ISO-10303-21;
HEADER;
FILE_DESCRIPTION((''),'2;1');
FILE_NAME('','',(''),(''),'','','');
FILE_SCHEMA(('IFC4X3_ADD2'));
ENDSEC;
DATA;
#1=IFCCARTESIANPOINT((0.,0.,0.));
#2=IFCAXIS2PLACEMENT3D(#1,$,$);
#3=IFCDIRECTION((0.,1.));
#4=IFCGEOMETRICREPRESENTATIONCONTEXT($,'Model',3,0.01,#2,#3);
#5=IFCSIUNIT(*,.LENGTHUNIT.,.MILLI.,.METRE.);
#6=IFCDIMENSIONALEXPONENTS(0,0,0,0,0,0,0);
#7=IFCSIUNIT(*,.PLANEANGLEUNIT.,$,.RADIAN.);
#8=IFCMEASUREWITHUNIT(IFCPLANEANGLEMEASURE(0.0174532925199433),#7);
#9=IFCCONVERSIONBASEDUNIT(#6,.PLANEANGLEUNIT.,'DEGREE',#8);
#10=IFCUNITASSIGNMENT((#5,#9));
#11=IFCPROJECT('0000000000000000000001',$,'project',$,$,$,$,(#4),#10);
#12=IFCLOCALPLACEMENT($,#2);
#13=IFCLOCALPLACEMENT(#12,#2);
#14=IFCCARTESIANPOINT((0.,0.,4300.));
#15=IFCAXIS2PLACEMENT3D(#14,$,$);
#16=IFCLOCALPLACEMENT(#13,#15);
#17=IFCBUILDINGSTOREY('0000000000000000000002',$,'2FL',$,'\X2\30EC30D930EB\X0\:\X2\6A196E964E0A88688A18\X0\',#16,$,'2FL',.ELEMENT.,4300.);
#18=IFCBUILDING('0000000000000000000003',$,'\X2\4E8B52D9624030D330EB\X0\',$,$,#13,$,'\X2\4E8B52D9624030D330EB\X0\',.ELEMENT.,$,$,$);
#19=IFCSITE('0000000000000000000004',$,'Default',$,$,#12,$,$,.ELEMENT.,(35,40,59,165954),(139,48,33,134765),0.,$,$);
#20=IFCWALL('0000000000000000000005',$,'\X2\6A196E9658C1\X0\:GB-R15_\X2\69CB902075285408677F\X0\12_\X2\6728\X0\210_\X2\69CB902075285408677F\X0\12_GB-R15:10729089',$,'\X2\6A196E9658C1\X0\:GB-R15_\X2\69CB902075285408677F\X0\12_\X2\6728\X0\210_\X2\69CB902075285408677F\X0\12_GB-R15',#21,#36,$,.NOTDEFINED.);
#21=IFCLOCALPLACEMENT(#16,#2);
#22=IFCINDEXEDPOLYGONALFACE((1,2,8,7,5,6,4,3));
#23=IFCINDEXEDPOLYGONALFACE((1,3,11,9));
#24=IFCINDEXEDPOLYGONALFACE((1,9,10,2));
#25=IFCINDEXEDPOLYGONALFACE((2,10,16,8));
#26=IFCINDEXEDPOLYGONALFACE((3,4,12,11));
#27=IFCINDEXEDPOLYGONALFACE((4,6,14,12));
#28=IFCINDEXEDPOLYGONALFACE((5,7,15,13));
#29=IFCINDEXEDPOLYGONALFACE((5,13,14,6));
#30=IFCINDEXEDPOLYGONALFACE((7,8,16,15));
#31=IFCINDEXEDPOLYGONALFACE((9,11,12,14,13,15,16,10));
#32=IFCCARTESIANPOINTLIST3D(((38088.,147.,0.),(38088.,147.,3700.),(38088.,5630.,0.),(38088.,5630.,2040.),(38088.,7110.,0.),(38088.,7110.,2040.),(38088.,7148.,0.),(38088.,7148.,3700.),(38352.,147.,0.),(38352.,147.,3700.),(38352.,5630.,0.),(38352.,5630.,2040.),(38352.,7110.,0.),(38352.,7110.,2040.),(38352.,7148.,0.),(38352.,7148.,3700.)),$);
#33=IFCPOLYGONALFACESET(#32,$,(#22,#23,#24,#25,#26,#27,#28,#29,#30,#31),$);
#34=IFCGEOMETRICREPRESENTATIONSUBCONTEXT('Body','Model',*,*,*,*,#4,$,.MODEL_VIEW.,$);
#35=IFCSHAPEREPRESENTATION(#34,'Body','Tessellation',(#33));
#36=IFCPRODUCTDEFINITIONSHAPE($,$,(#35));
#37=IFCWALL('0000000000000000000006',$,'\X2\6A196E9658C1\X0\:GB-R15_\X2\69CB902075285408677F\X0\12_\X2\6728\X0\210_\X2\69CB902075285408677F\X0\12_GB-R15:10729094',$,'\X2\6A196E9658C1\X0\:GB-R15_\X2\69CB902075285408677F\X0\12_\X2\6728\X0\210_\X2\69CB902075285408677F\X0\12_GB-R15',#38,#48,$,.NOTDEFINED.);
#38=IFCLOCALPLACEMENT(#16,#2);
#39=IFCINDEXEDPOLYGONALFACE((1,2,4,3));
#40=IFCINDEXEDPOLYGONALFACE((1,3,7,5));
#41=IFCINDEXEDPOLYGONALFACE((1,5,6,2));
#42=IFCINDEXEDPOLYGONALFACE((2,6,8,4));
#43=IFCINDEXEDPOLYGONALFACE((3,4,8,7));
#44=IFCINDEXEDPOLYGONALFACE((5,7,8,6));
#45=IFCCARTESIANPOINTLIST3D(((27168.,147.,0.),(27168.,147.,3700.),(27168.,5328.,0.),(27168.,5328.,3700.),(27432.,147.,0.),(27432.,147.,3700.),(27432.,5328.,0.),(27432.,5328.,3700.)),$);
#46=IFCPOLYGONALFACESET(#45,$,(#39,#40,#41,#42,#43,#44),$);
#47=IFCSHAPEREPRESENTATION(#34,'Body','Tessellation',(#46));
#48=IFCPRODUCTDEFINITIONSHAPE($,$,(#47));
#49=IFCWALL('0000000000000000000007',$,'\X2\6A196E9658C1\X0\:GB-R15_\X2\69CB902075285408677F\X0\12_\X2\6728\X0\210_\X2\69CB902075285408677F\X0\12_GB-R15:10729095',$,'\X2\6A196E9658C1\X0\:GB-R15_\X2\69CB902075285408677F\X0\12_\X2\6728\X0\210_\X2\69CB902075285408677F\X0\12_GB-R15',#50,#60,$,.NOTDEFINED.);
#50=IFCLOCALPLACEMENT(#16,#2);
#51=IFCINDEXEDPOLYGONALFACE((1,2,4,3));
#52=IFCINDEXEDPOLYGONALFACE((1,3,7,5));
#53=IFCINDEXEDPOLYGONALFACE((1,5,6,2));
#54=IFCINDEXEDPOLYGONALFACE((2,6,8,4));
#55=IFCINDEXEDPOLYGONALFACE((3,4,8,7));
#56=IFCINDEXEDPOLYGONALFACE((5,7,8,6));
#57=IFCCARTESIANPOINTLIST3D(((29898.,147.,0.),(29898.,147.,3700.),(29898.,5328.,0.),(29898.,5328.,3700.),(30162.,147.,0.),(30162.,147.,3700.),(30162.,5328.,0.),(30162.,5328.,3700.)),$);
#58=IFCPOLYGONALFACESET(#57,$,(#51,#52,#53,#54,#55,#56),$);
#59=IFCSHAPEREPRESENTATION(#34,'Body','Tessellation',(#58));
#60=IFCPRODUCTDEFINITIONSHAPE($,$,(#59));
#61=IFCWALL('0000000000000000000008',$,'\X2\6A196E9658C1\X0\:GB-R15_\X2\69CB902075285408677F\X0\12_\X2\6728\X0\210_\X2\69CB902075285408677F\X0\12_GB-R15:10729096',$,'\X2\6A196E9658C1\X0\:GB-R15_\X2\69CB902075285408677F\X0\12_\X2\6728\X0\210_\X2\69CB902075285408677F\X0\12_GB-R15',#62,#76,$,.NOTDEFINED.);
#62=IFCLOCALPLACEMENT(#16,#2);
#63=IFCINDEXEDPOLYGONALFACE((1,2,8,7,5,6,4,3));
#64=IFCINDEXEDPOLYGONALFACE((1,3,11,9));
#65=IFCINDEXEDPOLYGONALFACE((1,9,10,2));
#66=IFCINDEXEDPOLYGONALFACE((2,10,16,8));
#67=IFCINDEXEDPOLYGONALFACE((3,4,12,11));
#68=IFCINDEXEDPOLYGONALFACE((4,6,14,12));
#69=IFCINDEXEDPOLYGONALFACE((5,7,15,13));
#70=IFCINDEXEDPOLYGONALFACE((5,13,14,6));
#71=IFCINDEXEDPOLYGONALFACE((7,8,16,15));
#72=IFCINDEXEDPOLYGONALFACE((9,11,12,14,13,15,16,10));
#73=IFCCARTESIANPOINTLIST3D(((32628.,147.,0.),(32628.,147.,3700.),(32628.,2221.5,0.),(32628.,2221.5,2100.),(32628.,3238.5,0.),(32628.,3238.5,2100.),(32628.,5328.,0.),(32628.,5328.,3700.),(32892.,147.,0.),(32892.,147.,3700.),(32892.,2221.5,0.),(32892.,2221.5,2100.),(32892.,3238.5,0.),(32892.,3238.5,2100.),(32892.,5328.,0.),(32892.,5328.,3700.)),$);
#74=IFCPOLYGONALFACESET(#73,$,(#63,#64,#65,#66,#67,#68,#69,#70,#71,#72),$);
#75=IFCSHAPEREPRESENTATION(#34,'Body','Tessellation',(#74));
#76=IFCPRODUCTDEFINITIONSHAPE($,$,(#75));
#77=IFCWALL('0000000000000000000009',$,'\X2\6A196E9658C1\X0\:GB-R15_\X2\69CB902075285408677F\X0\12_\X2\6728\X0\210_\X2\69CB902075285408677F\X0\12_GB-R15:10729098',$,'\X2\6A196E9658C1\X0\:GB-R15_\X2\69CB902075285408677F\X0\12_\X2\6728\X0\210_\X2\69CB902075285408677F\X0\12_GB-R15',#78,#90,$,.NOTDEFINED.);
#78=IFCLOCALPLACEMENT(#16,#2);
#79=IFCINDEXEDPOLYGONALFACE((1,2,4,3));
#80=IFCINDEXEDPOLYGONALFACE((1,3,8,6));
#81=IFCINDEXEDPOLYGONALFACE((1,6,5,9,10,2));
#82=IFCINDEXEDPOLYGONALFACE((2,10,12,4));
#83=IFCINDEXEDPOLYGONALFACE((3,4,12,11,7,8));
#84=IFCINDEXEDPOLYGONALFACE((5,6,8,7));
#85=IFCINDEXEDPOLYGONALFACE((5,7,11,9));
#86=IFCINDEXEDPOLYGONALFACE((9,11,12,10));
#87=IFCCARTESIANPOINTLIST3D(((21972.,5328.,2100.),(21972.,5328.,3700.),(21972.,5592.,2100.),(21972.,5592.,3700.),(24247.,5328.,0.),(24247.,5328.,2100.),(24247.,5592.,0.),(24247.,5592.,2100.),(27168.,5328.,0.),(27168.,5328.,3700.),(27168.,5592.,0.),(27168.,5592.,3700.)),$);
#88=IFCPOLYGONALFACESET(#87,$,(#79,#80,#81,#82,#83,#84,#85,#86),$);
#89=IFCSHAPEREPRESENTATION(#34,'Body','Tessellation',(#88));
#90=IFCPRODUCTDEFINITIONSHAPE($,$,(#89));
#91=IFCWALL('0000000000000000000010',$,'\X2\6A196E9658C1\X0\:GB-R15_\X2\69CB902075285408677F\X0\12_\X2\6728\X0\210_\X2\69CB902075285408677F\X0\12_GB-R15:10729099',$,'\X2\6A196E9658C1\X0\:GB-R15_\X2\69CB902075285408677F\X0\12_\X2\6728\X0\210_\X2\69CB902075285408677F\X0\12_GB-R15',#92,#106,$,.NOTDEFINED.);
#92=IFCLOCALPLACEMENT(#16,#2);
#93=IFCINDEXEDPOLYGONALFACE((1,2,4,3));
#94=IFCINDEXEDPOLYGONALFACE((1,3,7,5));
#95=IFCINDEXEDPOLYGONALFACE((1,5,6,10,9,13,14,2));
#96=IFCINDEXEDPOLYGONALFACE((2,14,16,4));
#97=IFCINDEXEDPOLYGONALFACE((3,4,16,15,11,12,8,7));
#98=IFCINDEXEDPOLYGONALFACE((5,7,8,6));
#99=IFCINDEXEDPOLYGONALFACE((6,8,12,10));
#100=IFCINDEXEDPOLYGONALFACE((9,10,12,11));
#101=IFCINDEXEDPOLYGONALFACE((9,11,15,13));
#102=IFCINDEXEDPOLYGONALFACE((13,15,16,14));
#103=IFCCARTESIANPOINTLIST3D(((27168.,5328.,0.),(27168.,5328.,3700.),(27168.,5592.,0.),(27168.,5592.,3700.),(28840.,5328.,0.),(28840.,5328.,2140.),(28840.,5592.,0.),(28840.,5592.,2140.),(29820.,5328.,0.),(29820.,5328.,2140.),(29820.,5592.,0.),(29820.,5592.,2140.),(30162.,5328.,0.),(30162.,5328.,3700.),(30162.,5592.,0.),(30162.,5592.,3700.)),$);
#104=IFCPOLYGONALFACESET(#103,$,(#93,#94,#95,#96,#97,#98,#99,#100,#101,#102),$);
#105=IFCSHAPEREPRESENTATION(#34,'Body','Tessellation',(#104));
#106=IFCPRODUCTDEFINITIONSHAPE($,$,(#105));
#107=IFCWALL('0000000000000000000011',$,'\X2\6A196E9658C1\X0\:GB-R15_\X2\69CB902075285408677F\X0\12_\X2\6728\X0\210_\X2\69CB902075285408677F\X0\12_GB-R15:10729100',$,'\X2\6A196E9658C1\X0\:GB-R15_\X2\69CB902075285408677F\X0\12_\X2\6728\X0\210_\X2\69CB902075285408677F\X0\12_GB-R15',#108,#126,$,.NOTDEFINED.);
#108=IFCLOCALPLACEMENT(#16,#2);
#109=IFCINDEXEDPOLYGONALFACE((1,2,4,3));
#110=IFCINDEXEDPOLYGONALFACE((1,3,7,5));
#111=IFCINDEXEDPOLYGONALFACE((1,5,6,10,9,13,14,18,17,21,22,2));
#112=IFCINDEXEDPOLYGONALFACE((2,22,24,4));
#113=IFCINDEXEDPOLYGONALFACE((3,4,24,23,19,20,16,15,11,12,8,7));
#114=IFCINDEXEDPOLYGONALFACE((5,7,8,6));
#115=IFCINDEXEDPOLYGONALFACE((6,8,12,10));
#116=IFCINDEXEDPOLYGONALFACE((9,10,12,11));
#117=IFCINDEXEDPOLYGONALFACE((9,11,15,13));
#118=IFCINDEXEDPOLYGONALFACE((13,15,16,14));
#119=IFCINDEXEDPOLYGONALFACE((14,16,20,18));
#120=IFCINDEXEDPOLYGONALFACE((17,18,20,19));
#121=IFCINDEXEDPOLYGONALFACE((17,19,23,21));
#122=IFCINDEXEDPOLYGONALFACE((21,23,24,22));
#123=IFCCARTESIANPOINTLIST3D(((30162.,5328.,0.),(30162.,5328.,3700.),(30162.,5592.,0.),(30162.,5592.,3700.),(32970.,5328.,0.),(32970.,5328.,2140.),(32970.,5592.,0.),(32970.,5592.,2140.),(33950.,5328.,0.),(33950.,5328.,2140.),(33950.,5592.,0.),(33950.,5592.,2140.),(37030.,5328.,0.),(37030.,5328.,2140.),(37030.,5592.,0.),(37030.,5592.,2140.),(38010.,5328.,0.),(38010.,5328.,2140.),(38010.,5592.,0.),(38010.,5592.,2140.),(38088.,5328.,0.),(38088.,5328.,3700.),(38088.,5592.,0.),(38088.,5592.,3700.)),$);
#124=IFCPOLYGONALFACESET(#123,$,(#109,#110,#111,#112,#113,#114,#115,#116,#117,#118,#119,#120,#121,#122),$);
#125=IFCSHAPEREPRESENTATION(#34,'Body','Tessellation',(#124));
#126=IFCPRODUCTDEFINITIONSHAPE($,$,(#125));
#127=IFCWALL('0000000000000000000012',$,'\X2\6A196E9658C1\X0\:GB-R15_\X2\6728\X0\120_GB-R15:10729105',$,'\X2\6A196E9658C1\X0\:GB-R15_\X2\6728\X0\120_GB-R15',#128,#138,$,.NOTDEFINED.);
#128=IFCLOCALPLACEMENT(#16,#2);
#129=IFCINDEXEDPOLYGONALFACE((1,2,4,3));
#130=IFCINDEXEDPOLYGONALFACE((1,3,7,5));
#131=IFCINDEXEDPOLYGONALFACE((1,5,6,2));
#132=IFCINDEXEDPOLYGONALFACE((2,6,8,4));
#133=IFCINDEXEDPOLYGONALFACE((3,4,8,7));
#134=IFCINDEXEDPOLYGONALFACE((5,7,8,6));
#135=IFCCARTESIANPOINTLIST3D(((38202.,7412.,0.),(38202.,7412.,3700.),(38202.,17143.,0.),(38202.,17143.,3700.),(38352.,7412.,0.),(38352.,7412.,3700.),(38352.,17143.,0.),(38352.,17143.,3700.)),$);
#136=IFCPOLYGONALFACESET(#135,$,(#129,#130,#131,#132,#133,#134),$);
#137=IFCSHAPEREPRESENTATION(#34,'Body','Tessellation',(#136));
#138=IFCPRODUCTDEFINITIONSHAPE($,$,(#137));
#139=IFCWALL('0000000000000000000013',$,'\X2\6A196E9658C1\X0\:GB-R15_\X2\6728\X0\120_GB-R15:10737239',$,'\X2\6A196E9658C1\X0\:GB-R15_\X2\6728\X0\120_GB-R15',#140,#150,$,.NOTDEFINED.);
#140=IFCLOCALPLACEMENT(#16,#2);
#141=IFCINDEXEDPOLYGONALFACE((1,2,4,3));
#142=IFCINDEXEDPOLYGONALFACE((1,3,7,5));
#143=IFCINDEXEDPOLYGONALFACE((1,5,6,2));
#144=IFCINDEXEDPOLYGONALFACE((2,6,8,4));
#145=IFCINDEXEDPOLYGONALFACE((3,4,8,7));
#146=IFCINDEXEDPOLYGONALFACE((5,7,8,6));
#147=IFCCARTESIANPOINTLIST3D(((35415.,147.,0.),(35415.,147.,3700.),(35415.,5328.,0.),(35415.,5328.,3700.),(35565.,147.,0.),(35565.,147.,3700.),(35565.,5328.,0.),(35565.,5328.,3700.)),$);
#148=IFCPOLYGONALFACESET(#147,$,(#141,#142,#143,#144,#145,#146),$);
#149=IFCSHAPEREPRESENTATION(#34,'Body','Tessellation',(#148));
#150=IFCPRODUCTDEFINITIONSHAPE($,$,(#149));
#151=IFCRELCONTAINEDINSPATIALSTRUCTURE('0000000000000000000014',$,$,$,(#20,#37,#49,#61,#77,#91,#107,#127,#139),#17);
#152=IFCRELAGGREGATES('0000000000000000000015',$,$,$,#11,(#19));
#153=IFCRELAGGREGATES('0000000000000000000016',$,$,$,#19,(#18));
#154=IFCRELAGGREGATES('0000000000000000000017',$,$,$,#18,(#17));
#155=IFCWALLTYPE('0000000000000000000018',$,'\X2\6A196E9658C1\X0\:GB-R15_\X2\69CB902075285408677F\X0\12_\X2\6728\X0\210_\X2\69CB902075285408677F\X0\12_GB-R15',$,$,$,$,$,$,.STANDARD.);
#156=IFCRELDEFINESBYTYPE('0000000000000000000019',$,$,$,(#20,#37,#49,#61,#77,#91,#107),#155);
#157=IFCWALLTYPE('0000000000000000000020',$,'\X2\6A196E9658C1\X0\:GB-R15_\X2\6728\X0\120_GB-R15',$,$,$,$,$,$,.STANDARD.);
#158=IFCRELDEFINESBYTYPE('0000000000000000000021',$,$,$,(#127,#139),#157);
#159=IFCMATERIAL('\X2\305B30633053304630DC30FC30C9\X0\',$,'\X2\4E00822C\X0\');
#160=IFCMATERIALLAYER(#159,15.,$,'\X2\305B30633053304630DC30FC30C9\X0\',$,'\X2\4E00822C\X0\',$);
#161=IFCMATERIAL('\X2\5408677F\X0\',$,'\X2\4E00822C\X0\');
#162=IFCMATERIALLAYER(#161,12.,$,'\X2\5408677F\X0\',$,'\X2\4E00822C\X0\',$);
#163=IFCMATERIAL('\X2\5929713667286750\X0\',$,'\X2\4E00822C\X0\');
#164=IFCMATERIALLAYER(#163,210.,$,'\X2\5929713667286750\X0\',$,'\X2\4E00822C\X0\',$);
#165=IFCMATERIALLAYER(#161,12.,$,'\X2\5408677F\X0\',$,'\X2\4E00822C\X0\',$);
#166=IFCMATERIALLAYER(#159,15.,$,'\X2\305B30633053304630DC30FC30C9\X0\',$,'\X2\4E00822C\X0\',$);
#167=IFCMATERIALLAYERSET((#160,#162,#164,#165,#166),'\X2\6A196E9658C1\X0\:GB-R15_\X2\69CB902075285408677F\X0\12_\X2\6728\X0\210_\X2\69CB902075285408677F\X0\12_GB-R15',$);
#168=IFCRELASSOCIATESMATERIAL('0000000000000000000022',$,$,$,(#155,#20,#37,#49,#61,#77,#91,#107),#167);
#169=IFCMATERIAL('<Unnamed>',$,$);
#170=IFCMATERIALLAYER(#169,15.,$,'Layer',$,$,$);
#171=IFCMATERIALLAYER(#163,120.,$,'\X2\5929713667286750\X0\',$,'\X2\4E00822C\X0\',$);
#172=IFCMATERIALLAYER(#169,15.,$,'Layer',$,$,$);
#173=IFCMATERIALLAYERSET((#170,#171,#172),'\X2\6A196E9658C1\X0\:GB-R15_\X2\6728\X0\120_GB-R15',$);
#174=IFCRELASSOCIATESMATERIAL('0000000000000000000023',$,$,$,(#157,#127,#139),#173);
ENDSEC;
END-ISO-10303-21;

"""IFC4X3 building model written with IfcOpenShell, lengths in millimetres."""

from ifc_helpers import new_model, entity, si_unit, converted_unit, direction, frame, frame_2d, origin, place, context, subcontext, project, spatial, rectangle, extrude, material, layer, layer_set, type_object, element, save


model = new_model("IFC4X3")

# Units and contexts
model_context = context("Model", 3, precision=0.01, world=origin(), true_north=direction((0.0, 1.0)))
body_context = subcontext(model_context, "Body", "Model", "MODEL_VIEW")
ifc_project = project(units=[si_unit("LENGTHUNIT", "METRE", prefix="MILLI"), converted_unit("PLANEANGLEUNIT", "DEGREE", entity("IfcPlaneAngleMeasure", 0.0174532925199433), si_unit("PLANEANGLEUNIT", "RADIAN"), dimensions=[0, 0, 0, 0, 0, 0, 0])], contexts=[model_context])

# Site, building, storey
site_placement = place(None, origin())
site = spatial("IfcSite", under=ifc_project, at=site_placement, Name="Default", CompositionType="ELEMENT", RefLatitude=(35, 40, 59, 165954), RefLongitude=(139, 48, 33, 134765), RefElevation=0.0)
building_placement = place(site_placement, origin())
building = spatial("IfcBuilding", under=site, at=building_placement, Name="事務所ビル", LongName="事務所ビル", CompositionType="ELEMENT")
storey_placement = place(building_placement, frame((0.0, 0.0, 4300.0)))
storey = spatial("IfcBuildingStorey", under=building, at=storey_placement, Name="2FL", ObjectType="レベル:標準上表記", LongName="2FL", CompositionType="ELEMENT", Elevation=4300.0)

# Wall, opening
ifc_material_1 = material(Name="せっこうボード", Category="一般")
ifc_layer_1 = layer(ifc_material_1, 15.0, Name="せっこうボード", Category="一般")
ifc_material_2 = material(Name="合板", Category="一般")
ifc_layer_2 = layer(ifc_material_2, 12.0, Name="合板", Category="一般")
ifc_material_3 = material(Name="天然木材", Category="一般")
ifc_layer_3 = layer(ifc_material_3, 210.0, Name="天然木材", Category="一般")
ifc_layer_4 = layer(ifc_material_2, 12.0, Name="合板", Category="一般")
ifc_layer_5 = layer(ifc_material_1, 15.0, Name="せっこうボード", Category="一般")
ifc_layer_set_1 = layer_set([ifc_layer_1, ifc_layer_2, ifc_layer_3, ifc_layer_4, ifc_layer_5], Name="標準壁:GB-R15_構造用合板12_木210_構造用合板12_GB-R15")
wall_type_1 = type_object("IfcWallType", Name="標準壁:GB-R15_構造用合板12_木210_構造用合板12_GB-R15", PredefinedType="STANDARD", material=ifc_layer_set_1)
wall_1_placement = place(storey_placement, frame((38220.0, 147.0, 0.0), z_axis=(0.0, 0.0, 1.0), x_axis=(0.0, 1.0, 0.0)))
wall_1 = element("IfcWall", 1, at=wall_1_placement, inside=storey, type_object=wall_type_1, material=ifc_layer_set_1, Name="標準壁:GB-R15_構造用合板12_木210_構造用合板12_GB-R15:10729089", ObjectType="標準壁:GB-R15_構造用合板12_木210_構造用合板12_GB-R15", PredefinedType="NOTDEFINED", context=body_context, shape_type="SweptSolid", body=[
    extrude(rectangle(XDim=7001.0, YDim=264.0, at=frame_2d((3500.5, 0.0), x_axis=(1.0, 0.0))), origin(), (0.0, 0.0, 1.0), 3700.0),
])
opening_1_placement = place(wall_1_placement, frame((6963.0, 132.0, -15.0)))
element("IfcOpeningElement", 2, at=opening_1_placement, cuts=wall_1, PredefinedType="OPENING", context=body_context, shape_type="SweptSolid", body=[
    extrude(rectangle(XDim=2055.0, YDim=1480.0, at=frame_2d((1027.5, 740.0), x_axis=(-1.0, 0.0))), frame((0.0, 0.0, 0.0), z_axis=(0.0, -1.0, 0.0), x_axis=(0.0, 0.0, 1.0)), (0.0, 0.0, 1.0), 264.0),
])

# Walls
wall_2_placement = place(storey_placement, frame((27300.0, 147.0, 0.0), z_axis=(0.0, 0.0, 1.0), x_axis=(0.0, 1.0, 0.0)))
element("IfcWall", 3, at=wall_2_placement, inside=storey, type_object=wall_type_1, material=ifc_layer_set_1, Name="標準壁:GB-R15_構造用合板12_木210_構造用合板12_GB-R15:10729094", ObjectType="標準壁:GB-R15_構造用合板12_木210_構造用合板12_GB-R15", PredefinedType="NOTDEFINED", context=body_context, shape_type="SweptSolid", body=[
    extrude(rectangle(XDim=5181.0, YDim=264.0, at=frame_2d((2590.5, 0.0), x_axis=(-1.0, 0.0))), origin(), (0.0, 0.0, 1.0), 3700.0),
])
wall_3_placement = place(storey_placement, frame((30030.0, 147.0, 0.0), z_axis=(0.0, 0.0, 1.0), x_axis=(0.0, 1.0, 0.0)))
element("IfcWall", 4, at=wall_3_placement, inside=storey, type_object=wall_type_1, material=ifc_layer_set_1, Name="標準壁:GB-R15_構造用合板12_木210_構造用合板12_GB-R15:10729095", ObjectType="標準壁:GB-R15_構造用合板12_木210_構造用合板12_GB-R15", PredefinedType="NOTDEFINED", context=body_context, shape_type="SweptSolid", body=[
    extrude(rectangle(XDim=5181.0, YDim=264.0, at=frame_2d((2590.5, 0.0), x_axis=(-1.0, 0.0))), origin(), (0.0, 0.0, 1.0), 3700.0),
])

# Wall, opening
wall_4_placement = place(storey_placement, frame((32760.0, 147.0, 0.0), z_axis=(0.0, 0.0, 1.0), x_axis=(0.0, 1.0, 0.0)))
wall_4 = element("IfcWall", 5, at=wall_4_placement, inside=storey, type_object=wall_type_1, material=ifc_layer_set_1, Name="標準壁:GB-R15_構造用合板12_木210_構造用合板12_GB-R15:10729096", ObjectType="標準壁:GB-R15_構造用合板12_木210_構造用合板12_GB-R15", PredefinedType="NOTDEFINED", context=body_context, shape_type="SweptSolid", body=[
    extrude(rectangle(XDim=5181.0, YDim=264.0, at=frame_2d((2590.5, 0.0), x_axis=(-1.0, 0.0))), origin(), (0.0, 0.0, 1.0), 3700.0),
])
opening_2_placement = place(wall_4_placement, frame((2074.5, -132.0, 0.0)))
element("IfcOpeningElement", 6, at=opening_2_placement, cuts=wall_4, PredefinedType="OPENING", context=body_context, shape_type="SweptSolid", body=[
    extrude(rectangle(XDim=2100.0, YDim=1017.0, at=frame_2d((1050.0, 508.5), x_axis=(-1.0, 0.0))), frame((0.0, 0.0, 0.0), z_axis=(0.0, 1.0, 0.0), x_axis=(0.0, 0.0, 1.0)), (0.0, 0.0, 1.0), 264.0),
])

# Wall, openings
wall_5_placement = place(storey_placement, frame((21972.0, 5460.0, 0.0)))
wall_5 = element("IfcWall", 7, at=wall_5_placement, inside=storey, type_object=wall_type_1, material=ifc_layer_set_1, Name="標準壁:GB-R15_構造用合板12_木210_構造用合板12_GB-R15:10729098", ObjectType="標準壁:GB-R15_構造用合板12_木210_構造用合板12_GB-R15", PredefinedType="NOTDEFINED", context=body_context, shape_type="SweptSolid", body=[
    extrude(rectangle(XDim=5196.0, YDim=264.0, at=frame_2d((2598.0, 0.0), x_axis=(-1.0, 0.0))), origin(), (0.0, 0.0, 1.0), 3700.0),
])
opening_3_placement = place(wall_5_placement, frame((-21972.0, -5460.0, 3700.0)))
element("IfcOpeningElement", 8, at=opening_3_placement, cuts=wall_5, PredefinedType="OPENING", context=body_context, shape_type="SweptSolid", body=[
    extrude(rectangle(XDim=2100.0, YDim=2275.0, at=frame_2d((0.0, 0.0), x_axis=(0.0, 1.0))), frame((23109.5, 3804.0, 1050.0), z_axis=(0.0, 1.0, 0.0), x_axis=(1.0, 0.0, 0.0)), (0.0, 0.0, 1.0), 3048.0),
])
opening_4_placement = place(wall_5_placement, frame((0.0, -132.0, 0.0)))
element("IfcOpeningElement", 9, at=opening_4_placement, cuts=wall_5, PredefinedType="OPENING", context=body_context, shape_type="SweptSolid", body=[
    extrude(rectangle(XDim=2100.0, YDim=2275.0, at=frame_2d((1050.0, 1137.5), x_axis=(-1.0, 0.0))), frame((0.0, 0.0, 0.0), z_axis=(0.0, 1.0, 0.0), x_axis=(0.0, 0.0, 1.0)), (0.0, 0.0, 1.0), 264.0),
])

# Wall, opening
wall_6_placement = place(storey_placement, frame((27168.0, 5460.0, 0.0)))
wall_6 = element("IfcWall", 10, at=wall_6_placement, inside=storey, type_object=wall_type_1, material=ifc_layer_set_1, Name="標準壁:GB-R15_構造用合板12_木210_構造用合板12_GB-R15:10729099", ObjectType="標準壁:GB-R15_構造用合板12_木210_構造用合板12_GB-R15", PredefinedType="NOTDEFINED", context=body_context, shape_type="SweptSolid", body=[
    extrude(rectangle(XDim=2994.0, YDim=264.0, at=frame_2d((1497.0, 0.0), x_axis=(-1.0, 0.0))), origin(), (0.0, 0.0, 1.0), 3700.0),
])
opening_5_placement = place(wall_6_placement, frame((1672.0, -132.0, 0.0)))
element("IfcOpeningElement", 11, at=opening_5_placement, cuts=wall_6, PredefinedType="OPENING", context=body_context, shape_type="SweptSolid", body=[
    extrude(rectangle(XDim=2140.0, YDim=980.0, at=frame_2d((1070.0, 490.0), x_axis=(-1.0, 0.0))), frame((0.0, 0.0, 0.0), z_axis=(0.0, 1.0, 0.0), x_axis=(0.0, 0.0, 1.0)), (0.0, 0.0, 1.0), 264.0),
])

# Wall, openings
wall_7_placement = place(storey_placement, frame((30162.0, 5460.0, 0.0)))
wall_7 = element("IfcWall", 12, at=wall_7_placement, inside=storey, type_object=wall_type_1, material=ifc_layer_set_1, Name="標準壁:GB-R15_構造用合板12_木210_構造用合板12_GB-R15:10729100", ObjectType="標準壁:GB-R15_構造用合板12_木210_構造用合板12_GB-R15", PredefinedType="NOTDEFINED", context=body_context, shape_type="SweptSolid", body=[
    extrude(rectangle(XDim=7926.0, YDim=264.0, at=frame_2d((3963.0, 0.0), x_axis=(-1.0, 0.0))), origin(), (0.0, 0.0, 1.0), 3700.0),
])
opening_6_placement = place(wall_7_placement, frame((3788.0, 132.0, 0.0)))
element("IfcOpeningElement", 13, at=opening_6_placement, cuts=wall_7, PredefinedType="OPENING", context=body_context, shape_type="SweptSolid", body=[
    extrude(rectangle(XDim=2140.0, YDim=980.0, at=frame_2d((1070.0, 490.0), x_axis=(-1.0, 0.0))), frame((0.0, 0.0, 0.0), z_axis=(0.0, -1.0, 0.0), x_axis=(0.0, 0.0, 1.0)), (0.0, 0.0, 1.0), 264.0),
])
opening_7_placement = place(wall_7_placement, frame((7848.0, 132.0, 0.0)))
element("IfcOpeningElement", 14, at=opening_7_placement, cuts=wall_7, PredefinedType="OPENING", context=body_context, shape_type="SweptSolid", body=[
    extrude(rectangle(XDim=2140.0, YDim=980.0, at=frame_2d((1070.0, 490.0), x_axis=(-1.0, 0.0))), frame((0.0, 0.0, 0.0), z_axis=(0.0, -1.0, 0.0), x_axis=(0.0, 0.0, 1.0)), (0.0, 0.0, 1.0), 264.0),
])

# Walls
ifc_material_4 = material(Name="<Unnamed>")
ifc_layer_6 = layer(ifc_material_4, 15.0, Name="Layer")
ifc_layer_7 = layer(ifc_material_3, 120.0, Name="天然木材", Category="一般")
ifc_layer_8 = layer(ifc_material_4, 15.0, Name="Layer")
ifc_layer_set_2 = layer_set([ifc_layer_6, ifc_layer_7, ifc_layer_8], Name="標準壁:GB-R15_木120_GB-R15")
wall_type_2 = type_object("IfcWallType", Name="標準壁:GB-R15_木120_GB-R15", PredefinedType="STANDARD", material=ifc_layer_set_2)
wall_8_placement = place(storey_placement, frame((38277.0, 7412.0, 0.0), z_axis=(0.0, 0.0, 1.0), x_axis=(0.0, 1.0, 0.0)))
element("IfcWall", 15, at=wall_8_placement, inside=storey, type_object=wall_type_2, material=ifc_layer_set_2, Name="標準壁:GB-R15_木120_GB-R15:10729105", ObjectType="標準壁:GB-R15_木120_GB-R15", PredefinedType="NOTDEFINED", context=body_context, shape_type="SweptSolid", body=[
    extrude(rectangle(XDim=9731.0, YDim=150.0, at=frame_2d((4865.5, 0.0), x_axis=(-1.0, 0.0))), origin(), (0.0, 0.0, 1.0), 3700.0),
])
wall_9_placement = place(storey_placement, frame((35490.0, 147.0, 0.0), z_axis=(0.0, 0.0, 1.0), x_axis=(0.0, 1.0, 0.0)))
element("IfcWall", 16, at=wall_9_placement, inside=storey, type_object=wall_type_2, material=ifc_layer_set_2, Name="標準壁:GB-R15_木120_GB-R15:10737239", ObjectType="標準壁:GB-R15_木120_GB-R15", PredefinedType="NOTDEFINED", context=body_context, shape_type="SweptSolid", body=[
    extrude(rectangle(XDim=5181.0, YDim=150.0, at=frame_2d((2590.5, 0.0), x_axis=(-1.0, 0.0))), origin(), (0.0, 0.0, 1.0), 3700.0),
])

save(model, "model.ifc")
